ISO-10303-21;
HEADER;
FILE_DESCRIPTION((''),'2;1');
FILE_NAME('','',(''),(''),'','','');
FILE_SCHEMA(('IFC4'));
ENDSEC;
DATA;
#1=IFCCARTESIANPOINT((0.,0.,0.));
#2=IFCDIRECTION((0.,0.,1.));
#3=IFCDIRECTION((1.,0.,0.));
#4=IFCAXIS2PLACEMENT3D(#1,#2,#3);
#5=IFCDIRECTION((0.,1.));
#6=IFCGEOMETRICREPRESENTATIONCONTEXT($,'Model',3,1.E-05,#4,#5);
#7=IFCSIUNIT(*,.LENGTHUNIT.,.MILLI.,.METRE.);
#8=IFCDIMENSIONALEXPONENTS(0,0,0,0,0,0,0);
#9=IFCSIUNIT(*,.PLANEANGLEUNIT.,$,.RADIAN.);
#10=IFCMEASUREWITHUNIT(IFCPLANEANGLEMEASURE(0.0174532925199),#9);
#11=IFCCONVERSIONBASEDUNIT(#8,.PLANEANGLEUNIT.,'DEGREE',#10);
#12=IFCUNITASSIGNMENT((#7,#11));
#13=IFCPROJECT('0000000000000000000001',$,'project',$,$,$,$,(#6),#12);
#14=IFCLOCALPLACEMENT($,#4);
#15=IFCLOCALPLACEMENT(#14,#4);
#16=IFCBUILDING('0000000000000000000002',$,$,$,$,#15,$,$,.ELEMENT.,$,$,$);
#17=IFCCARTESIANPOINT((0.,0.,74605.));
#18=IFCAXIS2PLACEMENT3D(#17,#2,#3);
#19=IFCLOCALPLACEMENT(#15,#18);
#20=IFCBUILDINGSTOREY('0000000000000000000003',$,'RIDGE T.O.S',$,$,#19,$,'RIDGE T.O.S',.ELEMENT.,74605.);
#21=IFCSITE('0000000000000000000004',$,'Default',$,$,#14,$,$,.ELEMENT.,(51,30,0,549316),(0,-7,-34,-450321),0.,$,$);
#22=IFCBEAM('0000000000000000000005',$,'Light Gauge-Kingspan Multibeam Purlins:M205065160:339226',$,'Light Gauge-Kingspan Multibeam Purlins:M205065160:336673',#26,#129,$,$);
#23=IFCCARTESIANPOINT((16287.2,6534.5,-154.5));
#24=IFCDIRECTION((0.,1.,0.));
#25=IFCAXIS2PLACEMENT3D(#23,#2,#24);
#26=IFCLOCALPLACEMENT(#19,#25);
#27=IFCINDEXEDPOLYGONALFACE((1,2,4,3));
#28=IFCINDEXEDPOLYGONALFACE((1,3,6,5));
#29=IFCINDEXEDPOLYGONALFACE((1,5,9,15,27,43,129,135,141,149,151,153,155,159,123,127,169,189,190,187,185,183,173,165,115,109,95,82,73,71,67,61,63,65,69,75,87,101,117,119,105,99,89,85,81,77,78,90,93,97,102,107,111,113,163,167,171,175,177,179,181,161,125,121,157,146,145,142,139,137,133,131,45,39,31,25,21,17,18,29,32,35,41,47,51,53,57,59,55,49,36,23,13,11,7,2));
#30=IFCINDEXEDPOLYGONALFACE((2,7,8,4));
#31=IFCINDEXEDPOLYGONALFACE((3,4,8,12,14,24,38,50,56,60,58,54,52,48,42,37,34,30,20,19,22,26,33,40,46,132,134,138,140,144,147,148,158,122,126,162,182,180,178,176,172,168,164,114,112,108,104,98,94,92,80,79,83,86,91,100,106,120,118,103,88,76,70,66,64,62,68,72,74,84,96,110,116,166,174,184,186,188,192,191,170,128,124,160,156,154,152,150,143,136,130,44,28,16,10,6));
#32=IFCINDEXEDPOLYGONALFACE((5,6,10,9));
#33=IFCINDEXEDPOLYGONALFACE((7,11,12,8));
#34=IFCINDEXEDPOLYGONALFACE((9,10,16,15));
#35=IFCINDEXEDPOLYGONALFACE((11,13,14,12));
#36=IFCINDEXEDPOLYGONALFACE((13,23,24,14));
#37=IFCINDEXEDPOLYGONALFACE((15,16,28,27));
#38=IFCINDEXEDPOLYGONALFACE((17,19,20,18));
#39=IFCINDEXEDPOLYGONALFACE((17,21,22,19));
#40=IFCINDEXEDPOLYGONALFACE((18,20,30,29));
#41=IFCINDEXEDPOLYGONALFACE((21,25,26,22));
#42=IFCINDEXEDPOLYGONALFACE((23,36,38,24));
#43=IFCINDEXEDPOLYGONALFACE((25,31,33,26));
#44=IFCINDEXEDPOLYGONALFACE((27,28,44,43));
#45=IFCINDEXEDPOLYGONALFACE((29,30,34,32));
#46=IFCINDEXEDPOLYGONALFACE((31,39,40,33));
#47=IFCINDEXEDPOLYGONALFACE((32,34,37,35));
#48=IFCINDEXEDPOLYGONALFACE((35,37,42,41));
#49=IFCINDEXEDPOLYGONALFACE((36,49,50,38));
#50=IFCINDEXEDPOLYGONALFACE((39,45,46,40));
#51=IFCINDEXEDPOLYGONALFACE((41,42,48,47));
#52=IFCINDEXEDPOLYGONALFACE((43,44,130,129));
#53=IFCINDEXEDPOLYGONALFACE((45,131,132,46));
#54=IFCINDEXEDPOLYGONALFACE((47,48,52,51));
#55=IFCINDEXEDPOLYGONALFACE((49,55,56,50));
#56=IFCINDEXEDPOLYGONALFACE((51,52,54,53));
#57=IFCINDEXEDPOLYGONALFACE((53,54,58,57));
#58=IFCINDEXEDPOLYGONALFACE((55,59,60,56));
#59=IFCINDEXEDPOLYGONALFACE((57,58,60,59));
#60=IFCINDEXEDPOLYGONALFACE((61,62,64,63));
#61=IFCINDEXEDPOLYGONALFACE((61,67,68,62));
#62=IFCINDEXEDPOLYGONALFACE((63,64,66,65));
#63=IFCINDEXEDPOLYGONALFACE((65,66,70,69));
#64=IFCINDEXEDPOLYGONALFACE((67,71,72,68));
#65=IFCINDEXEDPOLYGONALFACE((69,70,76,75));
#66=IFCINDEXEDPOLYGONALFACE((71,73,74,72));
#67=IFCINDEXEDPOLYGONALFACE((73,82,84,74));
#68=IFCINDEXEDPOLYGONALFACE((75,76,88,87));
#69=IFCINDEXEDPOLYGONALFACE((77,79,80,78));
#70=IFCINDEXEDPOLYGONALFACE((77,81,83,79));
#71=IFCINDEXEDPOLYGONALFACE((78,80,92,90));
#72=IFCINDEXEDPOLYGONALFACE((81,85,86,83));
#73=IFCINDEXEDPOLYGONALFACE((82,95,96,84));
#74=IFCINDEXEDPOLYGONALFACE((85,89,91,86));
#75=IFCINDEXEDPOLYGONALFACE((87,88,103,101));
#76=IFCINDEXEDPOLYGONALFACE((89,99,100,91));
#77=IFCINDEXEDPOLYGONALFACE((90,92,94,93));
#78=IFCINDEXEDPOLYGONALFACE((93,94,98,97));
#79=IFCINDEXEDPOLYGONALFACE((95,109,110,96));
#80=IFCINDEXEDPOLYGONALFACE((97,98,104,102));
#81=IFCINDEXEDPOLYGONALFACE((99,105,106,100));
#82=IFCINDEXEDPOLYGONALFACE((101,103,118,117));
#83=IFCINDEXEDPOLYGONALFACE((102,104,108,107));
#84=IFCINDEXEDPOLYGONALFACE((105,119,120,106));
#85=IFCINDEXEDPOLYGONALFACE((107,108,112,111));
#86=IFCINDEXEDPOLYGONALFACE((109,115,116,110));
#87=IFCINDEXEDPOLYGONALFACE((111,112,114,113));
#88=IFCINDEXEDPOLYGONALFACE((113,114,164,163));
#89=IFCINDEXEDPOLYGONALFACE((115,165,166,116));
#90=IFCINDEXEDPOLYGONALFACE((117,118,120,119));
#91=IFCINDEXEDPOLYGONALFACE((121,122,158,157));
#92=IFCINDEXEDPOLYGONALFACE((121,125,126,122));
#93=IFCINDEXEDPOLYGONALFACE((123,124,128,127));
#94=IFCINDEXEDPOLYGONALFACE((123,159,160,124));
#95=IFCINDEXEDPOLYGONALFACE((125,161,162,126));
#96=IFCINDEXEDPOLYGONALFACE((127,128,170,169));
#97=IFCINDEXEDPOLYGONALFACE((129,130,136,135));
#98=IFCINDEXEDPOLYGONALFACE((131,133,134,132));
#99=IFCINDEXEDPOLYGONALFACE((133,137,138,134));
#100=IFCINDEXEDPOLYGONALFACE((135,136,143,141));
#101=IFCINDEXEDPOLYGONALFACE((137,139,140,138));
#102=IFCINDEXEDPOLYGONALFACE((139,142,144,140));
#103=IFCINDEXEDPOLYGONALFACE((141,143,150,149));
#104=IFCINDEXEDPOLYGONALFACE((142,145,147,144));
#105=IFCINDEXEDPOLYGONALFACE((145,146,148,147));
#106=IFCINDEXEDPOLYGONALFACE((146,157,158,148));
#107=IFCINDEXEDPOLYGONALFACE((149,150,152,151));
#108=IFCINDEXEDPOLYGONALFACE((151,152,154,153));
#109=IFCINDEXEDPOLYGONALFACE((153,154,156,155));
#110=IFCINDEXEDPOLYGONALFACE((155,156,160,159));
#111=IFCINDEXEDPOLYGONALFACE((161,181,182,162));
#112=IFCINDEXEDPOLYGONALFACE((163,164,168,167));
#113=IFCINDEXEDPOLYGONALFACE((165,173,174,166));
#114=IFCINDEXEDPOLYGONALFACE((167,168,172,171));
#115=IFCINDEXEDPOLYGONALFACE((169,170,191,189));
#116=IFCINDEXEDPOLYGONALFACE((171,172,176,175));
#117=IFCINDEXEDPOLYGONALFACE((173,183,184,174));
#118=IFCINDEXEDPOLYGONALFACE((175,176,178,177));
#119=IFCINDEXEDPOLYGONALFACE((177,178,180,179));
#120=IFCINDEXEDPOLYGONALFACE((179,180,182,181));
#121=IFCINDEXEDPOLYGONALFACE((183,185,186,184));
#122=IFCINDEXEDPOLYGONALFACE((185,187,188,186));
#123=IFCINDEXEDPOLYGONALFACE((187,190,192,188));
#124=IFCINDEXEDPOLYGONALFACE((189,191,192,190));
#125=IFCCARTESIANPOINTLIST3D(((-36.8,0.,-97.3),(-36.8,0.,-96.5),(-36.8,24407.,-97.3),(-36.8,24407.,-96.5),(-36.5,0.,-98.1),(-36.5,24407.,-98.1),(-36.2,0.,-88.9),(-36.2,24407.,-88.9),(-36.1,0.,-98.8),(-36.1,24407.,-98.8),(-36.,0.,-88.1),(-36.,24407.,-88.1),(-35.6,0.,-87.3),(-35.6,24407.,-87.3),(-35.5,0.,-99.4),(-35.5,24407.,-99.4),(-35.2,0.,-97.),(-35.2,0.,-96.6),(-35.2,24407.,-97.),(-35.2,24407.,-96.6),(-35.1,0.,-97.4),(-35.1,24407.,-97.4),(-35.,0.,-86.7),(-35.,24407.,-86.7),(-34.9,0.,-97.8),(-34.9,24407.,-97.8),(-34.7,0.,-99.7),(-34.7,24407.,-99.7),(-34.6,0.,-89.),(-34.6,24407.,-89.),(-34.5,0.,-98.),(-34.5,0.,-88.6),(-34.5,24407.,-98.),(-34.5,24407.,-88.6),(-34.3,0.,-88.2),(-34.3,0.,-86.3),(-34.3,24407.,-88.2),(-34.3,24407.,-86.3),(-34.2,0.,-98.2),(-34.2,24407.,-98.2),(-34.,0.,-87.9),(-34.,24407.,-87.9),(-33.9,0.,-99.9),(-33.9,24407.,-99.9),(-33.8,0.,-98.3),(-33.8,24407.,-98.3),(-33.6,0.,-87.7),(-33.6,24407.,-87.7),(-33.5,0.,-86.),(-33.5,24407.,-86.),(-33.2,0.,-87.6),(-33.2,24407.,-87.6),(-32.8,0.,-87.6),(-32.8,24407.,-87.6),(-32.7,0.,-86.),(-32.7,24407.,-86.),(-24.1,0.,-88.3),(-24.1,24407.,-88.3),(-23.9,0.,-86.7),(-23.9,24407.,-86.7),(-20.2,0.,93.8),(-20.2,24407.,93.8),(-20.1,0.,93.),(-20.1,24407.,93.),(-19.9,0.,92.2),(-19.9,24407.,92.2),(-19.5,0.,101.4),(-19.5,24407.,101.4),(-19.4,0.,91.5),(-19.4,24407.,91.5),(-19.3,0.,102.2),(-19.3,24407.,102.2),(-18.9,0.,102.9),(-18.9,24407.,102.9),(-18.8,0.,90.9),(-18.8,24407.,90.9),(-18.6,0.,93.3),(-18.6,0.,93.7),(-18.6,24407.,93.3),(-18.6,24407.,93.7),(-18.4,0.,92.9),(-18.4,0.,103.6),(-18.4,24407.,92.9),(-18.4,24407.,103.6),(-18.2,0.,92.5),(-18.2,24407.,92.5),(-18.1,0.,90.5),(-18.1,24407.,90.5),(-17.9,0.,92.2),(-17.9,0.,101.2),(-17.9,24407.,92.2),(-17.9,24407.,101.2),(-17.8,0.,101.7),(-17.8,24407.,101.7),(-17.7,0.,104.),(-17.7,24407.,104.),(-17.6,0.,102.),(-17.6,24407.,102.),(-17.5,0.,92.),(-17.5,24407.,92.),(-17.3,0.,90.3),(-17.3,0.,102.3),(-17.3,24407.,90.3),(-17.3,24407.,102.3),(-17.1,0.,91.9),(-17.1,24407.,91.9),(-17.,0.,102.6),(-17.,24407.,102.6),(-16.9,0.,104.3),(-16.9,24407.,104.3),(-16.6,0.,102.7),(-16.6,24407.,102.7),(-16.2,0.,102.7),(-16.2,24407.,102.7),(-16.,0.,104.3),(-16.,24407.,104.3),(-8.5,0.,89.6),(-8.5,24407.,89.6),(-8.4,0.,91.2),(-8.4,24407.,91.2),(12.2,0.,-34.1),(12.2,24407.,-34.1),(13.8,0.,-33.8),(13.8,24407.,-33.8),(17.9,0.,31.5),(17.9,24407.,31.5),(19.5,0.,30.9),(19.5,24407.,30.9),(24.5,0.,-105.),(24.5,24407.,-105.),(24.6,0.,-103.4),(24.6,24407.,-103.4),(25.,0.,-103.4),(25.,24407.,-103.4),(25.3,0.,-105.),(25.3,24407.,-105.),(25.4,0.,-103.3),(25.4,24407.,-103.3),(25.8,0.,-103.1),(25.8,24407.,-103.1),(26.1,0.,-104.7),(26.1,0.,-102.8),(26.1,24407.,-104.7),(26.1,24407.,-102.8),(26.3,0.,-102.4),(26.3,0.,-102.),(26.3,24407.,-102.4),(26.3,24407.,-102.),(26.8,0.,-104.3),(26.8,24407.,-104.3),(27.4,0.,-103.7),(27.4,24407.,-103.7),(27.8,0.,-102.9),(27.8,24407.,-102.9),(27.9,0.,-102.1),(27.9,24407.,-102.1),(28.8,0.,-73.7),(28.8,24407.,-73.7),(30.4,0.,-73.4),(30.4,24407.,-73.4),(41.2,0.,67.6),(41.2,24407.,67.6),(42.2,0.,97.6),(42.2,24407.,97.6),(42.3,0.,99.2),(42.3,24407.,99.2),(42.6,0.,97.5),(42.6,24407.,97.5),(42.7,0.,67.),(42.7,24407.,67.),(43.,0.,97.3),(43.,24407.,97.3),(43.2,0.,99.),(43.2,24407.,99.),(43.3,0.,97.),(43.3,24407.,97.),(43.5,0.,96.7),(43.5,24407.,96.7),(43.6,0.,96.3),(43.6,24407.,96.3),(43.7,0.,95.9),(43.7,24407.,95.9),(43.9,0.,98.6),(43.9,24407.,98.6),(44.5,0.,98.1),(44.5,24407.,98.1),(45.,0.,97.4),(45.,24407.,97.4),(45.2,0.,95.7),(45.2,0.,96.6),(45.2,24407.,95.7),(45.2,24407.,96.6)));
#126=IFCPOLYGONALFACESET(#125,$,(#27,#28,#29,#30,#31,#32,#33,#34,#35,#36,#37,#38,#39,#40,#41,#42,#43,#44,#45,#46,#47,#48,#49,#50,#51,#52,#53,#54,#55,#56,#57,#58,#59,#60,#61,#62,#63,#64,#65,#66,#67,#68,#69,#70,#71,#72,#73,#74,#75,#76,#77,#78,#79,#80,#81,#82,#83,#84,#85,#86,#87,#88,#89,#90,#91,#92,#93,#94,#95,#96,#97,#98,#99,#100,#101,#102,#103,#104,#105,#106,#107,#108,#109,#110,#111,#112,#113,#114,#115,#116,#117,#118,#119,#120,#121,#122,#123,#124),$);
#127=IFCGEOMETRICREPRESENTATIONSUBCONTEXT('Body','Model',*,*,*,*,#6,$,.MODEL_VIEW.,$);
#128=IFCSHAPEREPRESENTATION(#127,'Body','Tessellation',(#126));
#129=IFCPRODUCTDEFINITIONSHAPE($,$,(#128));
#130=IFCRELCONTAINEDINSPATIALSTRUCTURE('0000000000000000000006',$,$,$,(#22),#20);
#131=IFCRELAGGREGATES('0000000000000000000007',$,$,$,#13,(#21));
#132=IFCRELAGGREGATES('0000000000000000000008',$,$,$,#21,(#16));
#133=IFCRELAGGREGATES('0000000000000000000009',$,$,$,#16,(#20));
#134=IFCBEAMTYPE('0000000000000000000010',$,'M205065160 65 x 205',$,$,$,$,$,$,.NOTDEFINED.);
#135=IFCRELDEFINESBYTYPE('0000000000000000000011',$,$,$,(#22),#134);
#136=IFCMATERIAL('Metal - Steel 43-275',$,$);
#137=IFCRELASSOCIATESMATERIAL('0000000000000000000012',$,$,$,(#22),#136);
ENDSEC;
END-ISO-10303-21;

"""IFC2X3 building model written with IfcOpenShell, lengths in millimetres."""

from ifc_helpers import new_model, entity, si_unit, converted_unit, point, direction, frame, frame_2d, origin_with_axes, place, context, subcontext, project, spatial, polyline, circle_curve, parameter, trimmed, segment, composite_curve, outline, extrude, material, type_object, element, save


model = new_model("IFC2X3")

# Units and contexts
model_context = context("Model", 3, precision=1e-05, world=origin_with_axes(), true_north=direction((0.0, 1.0)))
body_context = subcontext(model_context, "Body", "Model", "MODEL_VIEW")
ifc_project = project(units=[si_unit("LENGTHUNIT", "METRE", prefix="MILLI"), converted_unit("PLANEANGLEUNIT", "DEGREE", entity("IfcPlaneAngleMeasure", 0.0174532925199), si_unit("PLANEANGLEUNIT", "RADIAN"), dimensions=[0, 0, 0, 0, 0, 0, 0])], contexts=[model_context])

# Site, building, storey
site_placement = place(None, origin_with_axes())
site = spatial("IfcSite", under=ifc_project, at=site_placement, Name="Default", CompositionType="ELEMENT", RefLatitude=(51, 30, 0, 549316), RefLongitude=(0, -7, -34, -450321), RefElevation=0.0)
building_placement = place(site_placement, origin_with_axes())
building = spatial("IfcBuilding", under=site, at=building_placement, CompositionType="ELEMENT")
storey_placement = place(building_placement, frame((0.0, 0.0, 74605.0), z_axis=(0.0, 0.0, 1.0), x_axis=(1.0, 0.0, 0.0)))
storey = spatial("IfcBuildingStorey", under=building, at=storey_placement, Name="RIDGE T.O.S", LongName="RIDGE T.O.S", CompositionType="ELEMENT", Elevation=74605.0)

# Beam
ifc_material = material(Name="Metal - Steel 43-275")
beam_type_1 = type_object("IfcBeamType", Name="M205065160 65 x 205", PredefinedType="NOTDEFINED")
beam_1_placement = place(storey_placement, frame((16287.2, 6534.5, -154.5), z_axis=(0.0, 0.0, 1.0), x_axis=(0.0, 1.0, 0.0)))
element("IfcBeam", 1, at=beam_1_placement, inside=storey, type_object=beam_type_1, material=ifc_material, Name="Light Gauge-Kingspan Multibeam Purlins:M205065160:339226", ObjectType="Light Gauge-Kingspan Multibeam Purlins:M205065160:336673", context=body_context, shape_type="SweptSolid", body=[
    extrude(outline(composite_curve([segment(polyline([(-33.5, -102.5), (25.1, -102.5)]), True, "CONTINUOUS"), segment(trimmed(circle_curve(frame_2d((25.1, -99.3), x_axis=(0.0, -1.0)), 3.2), [point((25.1, -102.5)), parameter(0.0)], [point((28.3, -99.3)), parameter(90.0)], True, "CARTESIAN"), True, "CONTINUOUS"), segment(polyline([(28.3, -99.3), (28.3, -91.7)]), True, "CONTINUOUS"), segment(trimmed(circle_curve(frame_2d((25.1, -91.7), x_axis=(1.0, 0.0)), 3.2), [point((28.3, -91.7)), parameter(0.0)], [point((25.1, -88.5)), parameter(90.0)], True, "CARTESIAN"), True, "CONTINUOUS"), segment(polyline([(25.1, -88.5), (16.3, -88.5), (16.3, -90.1), (25.1, -90.1)]), True, "CONTINUOUS"), segment(trimmed(circle_curve(frame_2d((25.1, -91.7), x_axis=(1.0, 0.0)), 1.6), [point((25.1, -90.1)), parameter(90.0)], [point((26.7, -91.7)), parameter(0.0)], False, "CARTESIAN"), True, "CONTINUOUS"), segment(polyline([(26.7, -91.7), (26.7, -99.3)]), True, "CONTINUOUS"), segment(trimmed(circle_curve(frame_2d((25.1, -99.3), x_axis=(0.0, -1.0)), 1.6), [point((26.7, -99.3)), parameter(90.0)], [point((25.1, -100.9)), parameter(0.0)], False, "CARTESIAN"), True, "CONTINUOUS"), segment(polyline([(25.1, -100.9), (-33.5, -100.9)]), True, "CONTINUOUS"), segment(trimmed(circle_curve(frame_2d((-33.5, -99.3), x_axis=(-1.0, 0.0)), 1.6), [point((-33.5, -100.9)), parameter(90.0)], [point((-35.1, -99.3)), parameter(0.0)], False, "CARTESIAN"), True, "CONTINUOUS"), segment(polyline([(-35.1, -99.3), (-35.1, -70.9), (-15.1, -32.9), (-15.1, 32.9), (-35.1, 70.9), (-35.1, 99.3)]), True, "CONTINUOUS"), segment(trimmed(circle_curve(frame_2d((-33.5, 99.3), x_axis=(0.0, 1.0)), 1.6), [point((-35.1, 99.3)), parameter(90.0)], [point((-33.5, 100.9)), parameter(0.0)], False, "CARTESIAN"), True, "CONTINUOUS"), segment(polyline([(-33.5, 100.9), (25.1, 100.9)]), True, "CONTINUOUS"), segment(trimmed(circle_curve(frame_2d((25.1, 99.3), x_axis=(1.0, 0.0)), 1.6), [point((25.1, 100.9)), parameter(90.0)], [point((26.7, 99.3)), parameter(0.0)], False, "CARTESIAN"), True, "CONTINUOUS"), segment(polyline([(26.7, 99.3), (26.7, 91.7)]), True, "CONTINUOUS"), segment(trimmed(circle_curve(frame_2d((25.1, 91.7), x_axis=(0.0, -1.0)), 1.6), [point((26.7, 91.7)), parameter(90.0)], [point((25.1, 90.1)), parameter(0.0)], False, "CARTESIAN"), True, "CONTINUOUS"), segment(polyline([(25.1, 90.1), (16.3, 90.1), (16.3, 88.5), (25.1, 88.5)]), True, "CONTINUOUS"), segment(trimmed(circle_curve(frame_2d((25.1, 91.7), x_axis=(0.0, -1.0)), 3.2), [point((25.1, 88.5)), parameter(0.0)], [point((28.3, 91.7)), parameter(90.0)], True, "CARTESIAN"), True, "CONTINUOUS"), segment(polyline([(28.3, 91.7), (28.3, 99.3)]), True, "CONTINUOUS"), segment(trimmed(circle_curve(frame_2d((25.1, 99.3), x_axis=(1.0, 0.0)), 3.2), [point((28.3, 99.3)), parameter(0.0)], [point((25.1, 102.5)), parameter(90.0)], True, "CARTESIAN"), True, "CONTINUOUS"), segment(polyline([(25.1, 102.5), (-33.5, 102.5)]), True, "CONTINUOUS"), segment(trimmed(circle_curve(frame_2d((-33.5, 99.3), x_axis=(0.0, 1.0)), 3.2), [point((-33.5, 102.5)), parameter(0.0)], [point((-36.7, 99.3)), parameter(90.0)], True, "CARTESIAN"), True, "CONTINUOUS"), segment(polyline([(-36.7, 99.3), (-36.7, 70.5), (-16.7, 32.5), (-16.7, -32.5), (-36.7, -70.5), (-36.7, -99.3)]), True, "CONTINUOUS"), segment(trimmed(circle_curve(frame_2d((-33.5, -99.3), x_axis=(-1.0, 0.0)), 3.2), [point((-36.7, -99.3)), parameter(0.0)], [point((-33.5, -102.5)), parameter(90.0)], True, "CARTESIAN"), True, "CONTINUOUS")], self_intersect=False)), frame((0.0, 24407.0, 0.0), z_axis=(0.0, -1.0, 0.0), x_axis=(-0.996195, 0.0, 0.087156)), (0.0, 0.0, 1.0), 24407.0),
])

save(model, "model.ifc")
